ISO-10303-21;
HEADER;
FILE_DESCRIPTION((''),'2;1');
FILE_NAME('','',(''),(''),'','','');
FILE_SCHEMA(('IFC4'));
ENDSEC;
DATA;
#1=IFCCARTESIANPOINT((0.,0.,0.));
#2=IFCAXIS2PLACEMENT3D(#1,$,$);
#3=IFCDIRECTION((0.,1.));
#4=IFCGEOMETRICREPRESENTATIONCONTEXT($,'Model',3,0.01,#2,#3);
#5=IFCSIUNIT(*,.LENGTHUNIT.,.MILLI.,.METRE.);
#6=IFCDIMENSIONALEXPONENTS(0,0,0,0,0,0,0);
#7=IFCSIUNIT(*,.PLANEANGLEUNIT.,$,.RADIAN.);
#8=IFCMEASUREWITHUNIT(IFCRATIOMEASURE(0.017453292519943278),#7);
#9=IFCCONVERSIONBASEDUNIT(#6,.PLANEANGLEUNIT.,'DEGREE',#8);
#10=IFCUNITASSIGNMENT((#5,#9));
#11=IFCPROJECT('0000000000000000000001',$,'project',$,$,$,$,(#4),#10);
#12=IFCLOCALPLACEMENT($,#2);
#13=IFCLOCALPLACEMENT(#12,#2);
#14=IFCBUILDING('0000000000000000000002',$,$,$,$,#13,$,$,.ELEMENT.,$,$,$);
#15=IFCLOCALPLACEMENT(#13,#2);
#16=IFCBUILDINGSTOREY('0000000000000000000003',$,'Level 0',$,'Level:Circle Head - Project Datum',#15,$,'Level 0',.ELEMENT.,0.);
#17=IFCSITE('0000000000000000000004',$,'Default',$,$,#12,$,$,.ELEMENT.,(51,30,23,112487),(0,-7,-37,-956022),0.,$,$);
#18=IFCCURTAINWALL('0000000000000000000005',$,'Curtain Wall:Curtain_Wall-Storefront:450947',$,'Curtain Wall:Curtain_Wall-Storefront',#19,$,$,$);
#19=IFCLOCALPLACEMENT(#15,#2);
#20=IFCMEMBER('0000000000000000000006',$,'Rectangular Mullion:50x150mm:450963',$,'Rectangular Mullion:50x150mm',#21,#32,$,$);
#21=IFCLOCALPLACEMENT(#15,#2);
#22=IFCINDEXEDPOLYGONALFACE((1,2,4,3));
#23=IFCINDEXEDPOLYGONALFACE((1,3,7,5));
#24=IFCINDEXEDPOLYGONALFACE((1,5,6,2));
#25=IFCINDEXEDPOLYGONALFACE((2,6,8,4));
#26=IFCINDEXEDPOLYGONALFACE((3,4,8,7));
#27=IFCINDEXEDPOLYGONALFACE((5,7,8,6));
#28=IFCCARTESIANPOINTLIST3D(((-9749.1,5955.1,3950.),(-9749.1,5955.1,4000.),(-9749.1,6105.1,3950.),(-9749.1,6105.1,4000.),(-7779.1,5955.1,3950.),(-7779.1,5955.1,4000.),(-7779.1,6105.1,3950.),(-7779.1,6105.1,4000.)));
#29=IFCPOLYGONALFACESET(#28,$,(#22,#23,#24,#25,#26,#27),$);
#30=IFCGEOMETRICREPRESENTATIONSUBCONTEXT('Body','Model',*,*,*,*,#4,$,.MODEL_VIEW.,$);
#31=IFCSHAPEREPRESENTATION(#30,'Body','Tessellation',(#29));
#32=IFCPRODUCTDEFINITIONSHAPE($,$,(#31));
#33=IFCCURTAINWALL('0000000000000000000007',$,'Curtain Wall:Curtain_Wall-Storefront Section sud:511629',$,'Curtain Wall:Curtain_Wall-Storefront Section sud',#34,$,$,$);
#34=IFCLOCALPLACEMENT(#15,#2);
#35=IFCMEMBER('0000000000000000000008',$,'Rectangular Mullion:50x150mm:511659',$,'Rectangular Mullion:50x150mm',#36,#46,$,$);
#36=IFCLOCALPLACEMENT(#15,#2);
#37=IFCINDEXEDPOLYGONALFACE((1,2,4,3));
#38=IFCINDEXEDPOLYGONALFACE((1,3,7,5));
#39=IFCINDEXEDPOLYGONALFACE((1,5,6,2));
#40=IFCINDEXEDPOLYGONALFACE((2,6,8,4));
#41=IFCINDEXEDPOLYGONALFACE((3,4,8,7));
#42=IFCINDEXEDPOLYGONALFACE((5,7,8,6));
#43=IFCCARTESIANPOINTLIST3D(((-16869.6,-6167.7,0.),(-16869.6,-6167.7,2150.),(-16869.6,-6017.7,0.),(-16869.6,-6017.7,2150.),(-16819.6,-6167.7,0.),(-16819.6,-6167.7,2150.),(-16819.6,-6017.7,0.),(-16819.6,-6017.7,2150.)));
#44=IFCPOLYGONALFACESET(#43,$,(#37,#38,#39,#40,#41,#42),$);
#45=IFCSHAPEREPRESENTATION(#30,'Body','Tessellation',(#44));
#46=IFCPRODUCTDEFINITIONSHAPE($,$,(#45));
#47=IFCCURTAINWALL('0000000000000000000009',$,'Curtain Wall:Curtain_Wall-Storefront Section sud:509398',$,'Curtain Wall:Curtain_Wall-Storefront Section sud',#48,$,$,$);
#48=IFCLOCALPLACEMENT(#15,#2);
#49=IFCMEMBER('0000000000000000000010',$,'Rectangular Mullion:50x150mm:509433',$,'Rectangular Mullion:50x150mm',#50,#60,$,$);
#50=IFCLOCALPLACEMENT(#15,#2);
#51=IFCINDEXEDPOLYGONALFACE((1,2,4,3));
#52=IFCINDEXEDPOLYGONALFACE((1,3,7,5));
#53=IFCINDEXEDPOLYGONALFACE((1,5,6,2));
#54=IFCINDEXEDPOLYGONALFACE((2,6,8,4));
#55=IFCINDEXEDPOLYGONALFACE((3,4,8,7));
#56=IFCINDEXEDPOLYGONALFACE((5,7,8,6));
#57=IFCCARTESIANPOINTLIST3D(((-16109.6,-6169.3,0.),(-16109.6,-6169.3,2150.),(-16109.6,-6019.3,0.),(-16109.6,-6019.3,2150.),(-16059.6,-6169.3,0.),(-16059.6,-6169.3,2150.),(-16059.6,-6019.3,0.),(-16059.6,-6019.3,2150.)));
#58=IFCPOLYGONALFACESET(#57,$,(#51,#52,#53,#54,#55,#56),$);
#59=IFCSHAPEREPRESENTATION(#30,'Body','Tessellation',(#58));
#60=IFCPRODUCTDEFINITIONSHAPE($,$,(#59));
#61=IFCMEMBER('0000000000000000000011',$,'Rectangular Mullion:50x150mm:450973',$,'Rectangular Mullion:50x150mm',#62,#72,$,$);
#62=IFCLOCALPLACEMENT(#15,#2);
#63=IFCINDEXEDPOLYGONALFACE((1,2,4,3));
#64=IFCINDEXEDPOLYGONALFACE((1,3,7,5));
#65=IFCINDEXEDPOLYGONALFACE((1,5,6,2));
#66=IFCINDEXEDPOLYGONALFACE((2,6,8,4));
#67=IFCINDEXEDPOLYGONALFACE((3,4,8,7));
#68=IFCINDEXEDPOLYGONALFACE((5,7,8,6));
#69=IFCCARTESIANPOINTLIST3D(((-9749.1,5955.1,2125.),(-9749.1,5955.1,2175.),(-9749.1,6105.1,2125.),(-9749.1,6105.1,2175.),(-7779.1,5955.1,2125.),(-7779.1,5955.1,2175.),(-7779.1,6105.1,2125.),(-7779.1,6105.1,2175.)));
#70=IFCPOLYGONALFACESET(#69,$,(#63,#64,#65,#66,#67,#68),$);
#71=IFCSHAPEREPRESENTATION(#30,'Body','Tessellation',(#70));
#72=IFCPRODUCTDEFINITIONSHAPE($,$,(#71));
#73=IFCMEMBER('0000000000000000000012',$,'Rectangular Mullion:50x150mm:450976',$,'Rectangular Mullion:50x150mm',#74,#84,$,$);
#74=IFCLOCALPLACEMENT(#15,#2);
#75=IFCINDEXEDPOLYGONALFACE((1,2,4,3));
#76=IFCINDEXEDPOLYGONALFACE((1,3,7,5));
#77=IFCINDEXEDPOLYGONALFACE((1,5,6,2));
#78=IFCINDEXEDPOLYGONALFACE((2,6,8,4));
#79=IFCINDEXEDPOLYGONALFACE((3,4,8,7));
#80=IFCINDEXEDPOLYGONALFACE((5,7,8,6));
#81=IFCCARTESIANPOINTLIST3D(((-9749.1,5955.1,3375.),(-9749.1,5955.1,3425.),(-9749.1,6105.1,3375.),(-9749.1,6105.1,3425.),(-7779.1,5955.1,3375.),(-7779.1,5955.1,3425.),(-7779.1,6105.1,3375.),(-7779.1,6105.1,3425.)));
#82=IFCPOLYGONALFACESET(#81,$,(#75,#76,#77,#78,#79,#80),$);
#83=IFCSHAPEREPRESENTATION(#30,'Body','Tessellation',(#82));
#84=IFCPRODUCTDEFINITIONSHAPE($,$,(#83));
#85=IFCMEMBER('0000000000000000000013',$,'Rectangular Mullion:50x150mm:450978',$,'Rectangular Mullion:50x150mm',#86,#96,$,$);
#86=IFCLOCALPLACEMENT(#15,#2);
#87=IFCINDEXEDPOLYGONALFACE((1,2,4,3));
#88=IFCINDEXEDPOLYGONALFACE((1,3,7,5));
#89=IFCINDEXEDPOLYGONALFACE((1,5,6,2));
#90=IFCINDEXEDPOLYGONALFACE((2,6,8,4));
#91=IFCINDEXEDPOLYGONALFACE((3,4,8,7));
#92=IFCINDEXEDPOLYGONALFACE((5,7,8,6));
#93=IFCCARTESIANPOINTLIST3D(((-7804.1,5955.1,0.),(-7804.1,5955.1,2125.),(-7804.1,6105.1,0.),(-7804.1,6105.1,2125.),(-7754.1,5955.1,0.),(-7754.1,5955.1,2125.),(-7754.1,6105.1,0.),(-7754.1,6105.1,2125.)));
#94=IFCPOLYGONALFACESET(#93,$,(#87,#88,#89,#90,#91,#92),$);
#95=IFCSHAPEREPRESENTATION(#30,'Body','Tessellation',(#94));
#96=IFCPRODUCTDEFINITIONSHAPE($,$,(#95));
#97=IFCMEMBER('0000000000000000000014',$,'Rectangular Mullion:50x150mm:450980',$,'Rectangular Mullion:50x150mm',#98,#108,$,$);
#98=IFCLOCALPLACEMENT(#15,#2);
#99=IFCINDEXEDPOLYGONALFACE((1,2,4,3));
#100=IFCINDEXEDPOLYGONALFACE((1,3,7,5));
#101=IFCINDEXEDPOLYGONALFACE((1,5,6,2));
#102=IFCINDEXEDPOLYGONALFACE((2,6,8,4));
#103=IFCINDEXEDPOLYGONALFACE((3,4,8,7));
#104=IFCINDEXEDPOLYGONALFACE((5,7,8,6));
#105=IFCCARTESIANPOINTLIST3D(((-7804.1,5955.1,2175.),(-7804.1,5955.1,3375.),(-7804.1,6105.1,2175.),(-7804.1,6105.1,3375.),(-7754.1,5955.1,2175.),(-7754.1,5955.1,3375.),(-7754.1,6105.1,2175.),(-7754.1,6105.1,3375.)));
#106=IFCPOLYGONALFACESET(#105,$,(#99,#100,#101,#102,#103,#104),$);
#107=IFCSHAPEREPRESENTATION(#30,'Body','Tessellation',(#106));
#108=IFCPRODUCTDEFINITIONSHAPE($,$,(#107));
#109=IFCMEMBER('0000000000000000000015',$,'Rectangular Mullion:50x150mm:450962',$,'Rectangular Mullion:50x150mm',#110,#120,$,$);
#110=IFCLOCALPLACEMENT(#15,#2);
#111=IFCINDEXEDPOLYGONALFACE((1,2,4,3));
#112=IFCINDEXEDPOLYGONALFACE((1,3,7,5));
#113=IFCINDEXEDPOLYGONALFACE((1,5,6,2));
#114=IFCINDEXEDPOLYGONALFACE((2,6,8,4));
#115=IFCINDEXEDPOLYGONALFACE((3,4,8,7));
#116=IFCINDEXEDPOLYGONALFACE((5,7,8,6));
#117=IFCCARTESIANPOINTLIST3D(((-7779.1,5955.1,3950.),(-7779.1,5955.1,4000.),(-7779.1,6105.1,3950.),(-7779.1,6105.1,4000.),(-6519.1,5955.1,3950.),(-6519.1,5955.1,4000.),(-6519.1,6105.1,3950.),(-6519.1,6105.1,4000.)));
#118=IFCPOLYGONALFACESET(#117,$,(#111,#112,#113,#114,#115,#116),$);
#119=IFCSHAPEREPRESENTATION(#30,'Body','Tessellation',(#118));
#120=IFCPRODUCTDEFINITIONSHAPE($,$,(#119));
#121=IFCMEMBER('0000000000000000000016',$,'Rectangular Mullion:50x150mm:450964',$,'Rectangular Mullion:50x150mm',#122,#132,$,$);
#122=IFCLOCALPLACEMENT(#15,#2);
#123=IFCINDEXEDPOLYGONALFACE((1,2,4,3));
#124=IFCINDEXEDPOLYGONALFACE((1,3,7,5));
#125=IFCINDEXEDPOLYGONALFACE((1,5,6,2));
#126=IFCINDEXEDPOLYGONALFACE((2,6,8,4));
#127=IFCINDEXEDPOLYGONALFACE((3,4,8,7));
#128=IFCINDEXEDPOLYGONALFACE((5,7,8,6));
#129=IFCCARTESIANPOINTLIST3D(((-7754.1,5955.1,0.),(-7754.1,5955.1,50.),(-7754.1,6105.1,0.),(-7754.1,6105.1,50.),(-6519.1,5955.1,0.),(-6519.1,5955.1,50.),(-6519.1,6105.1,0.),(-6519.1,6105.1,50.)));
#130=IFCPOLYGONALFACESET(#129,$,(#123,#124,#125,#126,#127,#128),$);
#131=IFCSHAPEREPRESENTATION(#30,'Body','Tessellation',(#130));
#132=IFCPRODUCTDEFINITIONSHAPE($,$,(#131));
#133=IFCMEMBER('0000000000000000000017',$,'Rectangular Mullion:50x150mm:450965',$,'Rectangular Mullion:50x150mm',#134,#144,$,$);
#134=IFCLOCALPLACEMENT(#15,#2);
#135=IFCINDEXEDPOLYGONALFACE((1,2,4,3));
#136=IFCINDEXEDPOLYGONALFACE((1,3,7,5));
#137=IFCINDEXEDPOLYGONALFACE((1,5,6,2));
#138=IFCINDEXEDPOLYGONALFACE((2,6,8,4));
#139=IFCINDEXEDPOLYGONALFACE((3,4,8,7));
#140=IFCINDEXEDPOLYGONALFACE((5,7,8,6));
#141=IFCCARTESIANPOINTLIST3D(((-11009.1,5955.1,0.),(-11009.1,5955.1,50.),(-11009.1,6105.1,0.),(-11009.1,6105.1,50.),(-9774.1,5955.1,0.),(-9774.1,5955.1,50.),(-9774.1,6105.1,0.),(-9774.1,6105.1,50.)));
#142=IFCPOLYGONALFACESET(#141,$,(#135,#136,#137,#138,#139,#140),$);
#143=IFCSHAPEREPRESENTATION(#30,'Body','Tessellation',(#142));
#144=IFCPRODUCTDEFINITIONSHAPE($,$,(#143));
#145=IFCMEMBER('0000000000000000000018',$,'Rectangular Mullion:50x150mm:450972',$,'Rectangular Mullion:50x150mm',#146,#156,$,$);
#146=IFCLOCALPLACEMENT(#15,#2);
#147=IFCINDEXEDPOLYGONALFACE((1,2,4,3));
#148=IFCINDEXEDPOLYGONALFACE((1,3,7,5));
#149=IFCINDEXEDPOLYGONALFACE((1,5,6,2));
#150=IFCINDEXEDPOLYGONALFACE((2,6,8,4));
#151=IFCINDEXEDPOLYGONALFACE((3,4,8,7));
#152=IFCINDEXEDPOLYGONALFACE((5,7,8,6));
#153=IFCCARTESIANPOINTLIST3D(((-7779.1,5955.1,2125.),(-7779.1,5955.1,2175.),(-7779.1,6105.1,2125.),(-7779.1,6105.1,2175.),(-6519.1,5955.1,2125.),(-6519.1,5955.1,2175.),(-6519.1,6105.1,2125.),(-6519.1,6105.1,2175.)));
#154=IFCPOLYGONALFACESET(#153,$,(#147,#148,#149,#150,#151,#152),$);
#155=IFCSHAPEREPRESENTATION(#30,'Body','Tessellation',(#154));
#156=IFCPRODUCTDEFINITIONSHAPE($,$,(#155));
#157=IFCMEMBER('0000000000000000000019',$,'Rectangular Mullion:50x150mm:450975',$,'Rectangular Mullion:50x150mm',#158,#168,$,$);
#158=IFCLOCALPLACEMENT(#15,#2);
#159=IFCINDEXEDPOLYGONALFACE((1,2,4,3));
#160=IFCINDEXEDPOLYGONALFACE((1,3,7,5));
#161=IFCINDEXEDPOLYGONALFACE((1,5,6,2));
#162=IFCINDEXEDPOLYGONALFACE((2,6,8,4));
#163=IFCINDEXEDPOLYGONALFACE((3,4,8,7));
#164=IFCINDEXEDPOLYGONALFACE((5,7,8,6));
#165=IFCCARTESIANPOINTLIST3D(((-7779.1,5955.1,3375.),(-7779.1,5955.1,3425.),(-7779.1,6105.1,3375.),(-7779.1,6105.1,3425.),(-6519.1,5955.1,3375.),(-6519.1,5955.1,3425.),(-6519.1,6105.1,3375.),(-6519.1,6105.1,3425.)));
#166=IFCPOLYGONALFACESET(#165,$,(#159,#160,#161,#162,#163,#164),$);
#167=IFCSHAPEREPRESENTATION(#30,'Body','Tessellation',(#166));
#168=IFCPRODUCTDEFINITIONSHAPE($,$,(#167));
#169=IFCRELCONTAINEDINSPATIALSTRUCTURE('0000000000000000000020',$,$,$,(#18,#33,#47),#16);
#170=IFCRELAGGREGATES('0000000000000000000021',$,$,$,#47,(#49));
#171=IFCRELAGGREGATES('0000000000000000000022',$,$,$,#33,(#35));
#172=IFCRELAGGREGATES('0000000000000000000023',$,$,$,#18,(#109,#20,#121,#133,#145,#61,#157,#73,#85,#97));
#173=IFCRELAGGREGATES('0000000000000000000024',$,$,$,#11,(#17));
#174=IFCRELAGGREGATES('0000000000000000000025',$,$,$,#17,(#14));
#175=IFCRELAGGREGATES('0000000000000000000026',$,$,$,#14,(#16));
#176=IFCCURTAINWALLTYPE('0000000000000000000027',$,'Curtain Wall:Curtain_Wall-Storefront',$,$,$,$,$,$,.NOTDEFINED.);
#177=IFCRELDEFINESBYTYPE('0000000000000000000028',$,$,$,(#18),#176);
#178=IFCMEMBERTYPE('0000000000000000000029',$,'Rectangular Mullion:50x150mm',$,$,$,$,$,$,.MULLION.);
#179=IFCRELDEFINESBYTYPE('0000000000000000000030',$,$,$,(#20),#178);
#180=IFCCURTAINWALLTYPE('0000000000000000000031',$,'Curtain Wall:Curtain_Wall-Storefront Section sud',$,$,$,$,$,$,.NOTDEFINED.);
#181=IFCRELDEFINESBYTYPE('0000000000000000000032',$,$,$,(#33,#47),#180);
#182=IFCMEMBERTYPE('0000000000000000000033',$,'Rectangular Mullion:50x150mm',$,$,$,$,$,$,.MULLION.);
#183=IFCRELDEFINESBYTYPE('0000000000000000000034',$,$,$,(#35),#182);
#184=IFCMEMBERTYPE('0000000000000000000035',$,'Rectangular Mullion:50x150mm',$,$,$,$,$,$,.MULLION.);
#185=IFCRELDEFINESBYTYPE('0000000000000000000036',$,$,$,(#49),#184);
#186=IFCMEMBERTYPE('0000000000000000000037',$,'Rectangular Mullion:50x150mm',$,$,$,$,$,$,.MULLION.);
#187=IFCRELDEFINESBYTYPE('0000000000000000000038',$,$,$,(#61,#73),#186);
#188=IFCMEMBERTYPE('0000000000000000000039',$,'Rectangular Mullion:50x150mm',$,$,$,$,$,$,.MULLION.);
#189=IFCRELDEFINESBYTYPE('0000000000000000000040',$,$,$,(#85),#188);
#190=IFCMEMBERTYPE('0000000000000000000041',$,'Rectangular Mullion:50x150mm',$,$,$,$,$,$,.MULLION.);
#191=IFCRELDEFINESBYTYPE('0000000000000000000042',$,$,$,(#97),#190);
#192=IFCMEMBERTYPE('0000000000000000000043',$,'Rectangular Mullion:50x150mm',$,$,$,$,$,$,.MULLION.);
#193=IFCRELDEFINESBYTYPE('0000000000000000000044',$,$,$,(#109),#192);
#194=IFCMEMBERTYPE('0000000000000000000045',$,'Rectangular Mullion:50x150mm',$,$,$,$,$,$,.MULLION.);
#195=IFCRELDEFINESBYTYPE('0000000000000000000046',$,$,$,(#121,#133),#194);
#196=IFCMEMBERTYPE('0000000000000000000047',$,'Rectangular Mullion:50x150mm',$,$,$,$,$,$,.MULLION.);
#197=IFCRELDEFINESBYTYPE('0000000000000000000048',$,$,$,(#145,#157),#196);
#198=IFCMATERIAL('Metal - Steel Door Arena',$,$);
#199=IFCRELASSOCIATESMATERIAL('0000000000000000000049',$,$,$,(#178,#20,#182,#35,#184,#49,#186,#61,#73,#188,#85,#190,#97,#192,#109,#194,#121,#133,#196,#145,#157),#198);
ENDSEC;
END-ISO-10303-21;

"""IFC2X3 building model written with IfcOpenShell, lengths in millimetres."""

from ifc_helpers import new_model, entity, si_unit, converted_unit, direction, frame, origin, origin_2d_with_axis, place, context, subcontext, project, spatial, rectangle, extrude, source, transform, mapped, material, type_object, type_shapes, element, aggregate, save


model = new_model("IFC2X3")

# Units and contexts
model_context = context("Model", 3, precision=0.01, world=origin(), true_north=direction((0.0, 1.0)))
body_context = subcontext(model_context, "Body", "Model", "MODEL_VIEW")
ifc_project = project(units=[si_unit("LENGTHUNIT", "METRE", prefix="MILLI"), converted_unit("PLANEANGLEUNIT", "DEGREE", entity("IfcRatioMeasure", 0.017453292519943278), si_unit("PLANEANGLEUNIT", "RADIAN"), dimensions=[0, 0, 0, 0, 0, 0, 0])], contexts=[model_context])

# Site, building, storey
site_placement = place(None, origin())
site = spatial("IfcSite", under=ifc_project, at=site_placement, Name="Default", CompositionType="ELEMENT", RefLatitude=(51, 30, 23, 112487), RefLongitude=(0, -7, -37, -956022), RefElevation=0.0)
building_placement = place(site_placement, origin())
building = spatial("IfcBuilding", under=site, at=building_placement, CompositionType="ELEMENT")
storey_placement = place(building_placement, origin())
storey = spatial("IfcBuildingStorey", under=building, at=storey_placement, Name="Level 0", ObjectType="Level:Circle Head - Project Datum", LongName="Level 0", CompositionType="ELEMENT", Elevation=0.0)

# Curtain walls, members
curtain_wall_type_1 = type_object("IfcCurtainWallType", Name="Curtain Wall:Curtain_Wall-Storefront", PredefinedType="NOTDEFINED")
curtain_wall_1_placement = place(storey_placement, origin())
curtain_wall_1 = element("IfcCurtainWall", 1, at=curtain_wall_1_placement, inside=storey, type_object=curtain_wall_type_1, Name="Curtain Wall:Curtain_Wall-Storefront:450947", ObjectType="Curtain Wall:Curtain_Wall-Storefront")
ifc_material_1 = material(Name="Metal - Steel Door Arena")
member_type_1 = type_object("IfcMemberType", Name="Rectangular Mullion:50x150mm", PredefinedType="MULLION", material=ifc_material_1)
shared_shape_1 = source(origin(), body_context, "Body", "SweptSolid", [
    extrude(rectangle(XDim=150.0, YDim=50.0, at=origin_2d_with_axis()), frame((-25.0, 0.0, -1970.0), z_axis=(0.0, 0.0, 1.0), x_axis=(0.0, -1.0, 0.0)), (0.0, 0.0, 1.0), 1970.0),
])
type_shapes(member_type_1, [shared_shape_1])
member_1_placement = place(curtain_wall_1_placement, frame((-9749.1, 6030.1, 4000.0), z_axis=(-1.0, 0.0, 0.0), x_axis=(0.0, 0.0, 1.0)))
member_1 = element("IfcMember", 2, at=member_1_placement, type_object=member_type_1, material=ifc_material_1, Name="Rectangular Mullion:50x150mm:450963", ObjectType="Rectangular Mullion:50x150mm", context=body_context, shape_type="MappedRepresentation", body=[
    mapped(shared_shape_1, transform((0.0, 0.0, 0.0), scale=1.0)),
])
curtain_wall_type_2 = type_object("IfcCurtainWallType", Name="Curtain Wall:Curtain_Wall-Storefront Section sud", PredefinedType="NOTDEFINED")
curtain_wall_2_placement = place(storey_placement, origin())
curtain_wall_2 = element("IfcCurtainWall", 3, at=curtain_wall_2_placement, inside=storey, type_object=curtain_wall_type_2, Name="Curtain Wall:Curtain_Wall-Storefront Section sud:511629", ObjectType="Curtain Wall:Curtain_Wall-Storefront Section sud")
member_type_2 = type_object("IfcMemberType", Name="Rectangular Mullion:50x150mm", PredefinedType="MULLION", material=ifc_material_1)
shared_shape_2 = source(origin(), body_context, "Body", "SweptSolid", [
    extrude(rectangle(XDim=150.0, YDim=50.0, at=origin_2d_with_axis()), frame((-25.0, 0.0, -2150.0), z_axis=(0.0, 0.0, 1.0), x_axis=(0.0, -1.0, 0.0)), (0.0, 0.0, 1.0), 2150.0),
])
type_shapes(member_type_2, [shared_shape_2])
member_2_placement = place(curtain_wall_2_placement, frame((-16819.6, -6092.7, 0.0), z_axis=(0.0, 0.0, -1.0), x_axis=(1.0, 0.0, 0.0)))
member_2 = element("IfcMember", 4, at=member_2_placement, type_object=member_type_2, material=ifc_material_1, Name="Rectangular Mullion:50x150mm:511659", ObjectType="Rectangular Mullion:50x150mm", context=body_context, shape_type="MappedRepresentation", body=[
    mapped(shared_shape_2, transform((0.0, 0.0, 0.0), scale=1.0)),
])
curtain_wall_3_placement = place(storey_placement, origin())
curtain_wall_3 = element("IfcCurtainWall", 5, at=curtain_wall_3_placement, inside=storey, type_object=curtain_wall_type_2, Name="Curtain Wall:Curtain_Wall-Storefront Section sud:509398", ObjectType="Curtain Wall:Curtain_Wall-Storefront Section sud")
member_type_3 = type_object("IfcMemberType", Name="Rectangular Mullion:50x150mm", PredefinedType="MULLION", material=ifc_material_1)
shared_shape_3 = source(origin(), body_context, "Body", "SweptSolid", [
    extrude(rectangle(XDim=150.0, YDim=50.0, at=origin_2d_with_axis()), frame((-25.0, 0.0, -2150.0), z_axis=(0.0, 0.0, 1.0), x_axis=(0.0, -1.0, 0.0)), (0.0, 0.0, 1.0), 2150.0),
])
type_shapes(member_type_3, [shared_shape_3])
member_3_placement = place(curtain_wall_3_placement, frame((-16109.6, -6094.3, 2150.0), z_axis=(0.0, 0.0, 1.0), x_axis=(-1.0, 0.0, 0.0)))
member_3 = element("IfcMember", 6, at=member_3_placement, type_object=member_type_3, material=ifc_material_1, Name="Rectangular Mullion:50x150mm:509433", ObjectType="Rectangular Mullion:50x150mm", context=body_context, shape_type="MappedRepresentation", body=[
    mapped(shared_shape_3, transform((0.0, 0.0, 0.0), scale=1.0)),
])

# Members
member_type_4 = type_object("IfcMemberType", Name="Rectangular Mullion:50x150mm", PredefinedType="MULLION", material=ifc_material_1)
shared_shape_4 = source(origin(), body_context, "Body", "SweptSolid", [
    extrude(rectangle(XDim=150.0, YDim=50.0, at=origin_2d_with_axis()), frame((0.0, 0.0, -1970.0), z_axis=(0.0, 0.0, 1.0), x_axis=(0.0, -1.0, 0.0)), (0.0, 0.0, 1.0), 1970.0),
])
type_shapes(member_type_4, [shared_shape_4])
member_4_placement = place(curtain_wall_1_placement, frame((-9749.1, 6030.1, 2150.0), z_axis=(-1.0, 0.0, 0.0), x_axis=(0.0, 0.0, 1.0)))
member_4 = element("IfcMember", 7, at=member_4_placement, type_object=member_type_4, material=ifc_material_1, Name="Rectangular Mullion:50x150mm:450973", ObjectType="Rectangular Mullion:50x150mm", context=body_context, shape_type="MappedRepresentation", body=[
    mapped(shared_shape_4, transform((0.0, 0.0, 0.0), scale=1.0)),
])
member_5_placement = place(curtain_wall_1_placement, frame((-9749.1, 6030.1, 3400.0), z_axis=(-1.0, 0.0, 0.0), x_axis=(0.0, 0.0, 1.0)))
member_5 = element("IfcMember", 8, at=member_5_placement, type_object=member_type_4, material=ifc_material_1, Name="Rectangular Mullion:50x150mm:450976", ObjectType="Rectangular Mullion:50x150mm", context=body_context, shape_type="MappedRepresentation", body=[
    mapped(shared_shape_4, transform((0.0, 0.0, 0.0), scale=1.0)),
])
member_type_5 = type_object("IfcMemberType", Name="Rectangular Mullion:50x150mm", PredefinedType="MULLION", material=ifc_material_1)
shared_shape_5 = source(origin(), body_context, "Body", "SweptSolid", [
    extrude(rectangle(XDim=150.0, YDim=50.0, at=origin_2d_with_axis()), frame((0.0, 0.0, -2125.0), z_axis=(0.0, 0.0, 1.0), x_axis=(0.0, -1.0, 0.0)), (0.0, 0.0, 1.0), 2125.0),
])
type_shapes(member_type_5, [shared_shape_5])
member_6_placement = place(curtain_wall_1_placement, frame((-7779.1, 6030.1, 0.0), z_axis=(0.0, 0.0, -1.0), x_axis=(-1.0, 0.0, 0.0)))
member_6 = element("IfcMember", 9, at=member_6_placement, type_object=member_type_5, material=ifc_material_1, Name="Rectangular Mullion:50x150mm:450978", ObjectType="Rectangular Mullion:50x150mm", context=body_context, shape_type="MappedRepresentation", body=[
    mapped(shared_shape_5, transform((0.0, 0.0, 0.0), scale=1.0)),
])
member_type_6 = type_object("IfcMemberType", Name="Rectangular Mullion:50x150mm", PredefinedType="MULLION", material=ifc_material_1)
shared_shape_6 = source(origin(), body_context, "Body", "SweptSolid", [
    extrude(rectangle(XDim=150.0, YDim=50.0, at=origin_2d_with_axis()), frame((0.0, 0.0, -1200.0), z_axis=(0.0, 0.0, 1.0), x_axis=(0.0, -1.0, 0.0)), (0.0, 0.0, 1.0), 1200.0),
])
type_shapes(member_type_6, [shared_shape_6])
member_7_placement = place(curtain_wall_1_placement, frame((-7779.1, 6030.1, 2175.0), z_axis=(0.0, 0.0, -1.0), x_axis=(-1.0, 0.0, 0.0)))
member_7 = element("IfcMember", 10, at=member_7_placement, type_object=member_type_6, material=ifc_material_1, Name="Rectangular Mullion:50x150mm:450980", ObjectType="Rectangular Mullion:50x150mm", context=body_context, shape_type="MappedRepresentation", body=[
    mapped(shared_shape_6, transform((0.0, 0.0, 0.0), scale=1.0)),
])
member_type_7 = type_object("IfcMemberType", Name="Rectangular Mullion:50x150mm", PredefinedType="MULLION", material=ifc_material_1)
shared_shape_7 = source(origin(), body_context, "Body", "SweptSolid", [
    extrude(rectangle(XDim=150.0, YDim=50.0, at=origin_2d_with_axis()), frame((-25.0, 0.0, -1260.0), z_axis=(0.0, 0.0, 1.0), x_axis=(0.0, -1.0, 0.0)), (0.0, 0.0, 1.0), 1260.0),
])
type_shapes(member_type_7, [shared_shape_7])
member_8_placement = place(curtain_wall_1_placement, frame((-7779.1, 6030.1, 4000.0), z_axis=(-1.0, 0.0, 0.0), x_axis=(0.0, 0.0, 1.0)))
member_8 = element("IfcMember", 11, at=member_8_placement, type_object=member_type_7, material=ifc_material_1, Name="Rectangular Mullion:50x150mm:450962", ObjectType="Rectangular Mullion:50x150mm", context=body_context, shape_type="MappedRepresentation", body=[
    mapped(shared_shape_7, transform((0.0, 0.0, 0.0), scale=1.0)),
])
member_type_8 = type_object("IfcMemberType", Name="Rectangular Mullion:50x150mm", PredefinedType="MULLION", material=ifc_material_1)
shared_shape_8 = source(origin(), body_context, "Body", "SweptSolid", [
    extrude(rectangle(XDim=150.0, YDim=50.0, at=origin_2d_with_axis()), frame((-25.0, 0.0, -1235.0), z_axis=(0.0, 0.0, 1.0), x_axis=(0.0, -1.0, 0.0)), (0.0, 0.0, 1.0), 1235.0),
])
type_shapes(member_type_8, [shared_shape_8])
member_9_placement = place(curtain_wall_1_placement, frame((-6519.1, 6030.1, 0.0), z_axis=(1.0, 0.0, 0.0), x_axis=(0.0, 0.0, -1.0)))
member_9 = element("IfcMember", 12, at=member_9_placement, type_object=member_type_8, material=ifc_material_1, Name="Rectangular Mullion:50x150mm:450964", ObjectType="Rectangular Mullion:50x150mm", context=body_context, shape_type="MappedRepresentation", body=[
    mapped(shared_shape_8, transform((0.0, 0.0, 0.0), scale=1.0)),
])
member_10_placement = place(curtain_wall_1_placement, frame((-9774.1, 6030.1, 0.0), z_axis=(1.0, 0.0, 0.0), x_axis=(0.0, 0.0, -1.0)))
member_10 = element("IfcMember", 13, at=member_10_placement, type_object=member_type_8, material=ifc_material_1, Name="Rectangular Mullion:50x150mm:450965", ObjectType="Rectangular Mullion:50x150mm", context=body_context, shape_type="MappedRepresentation", body=[
    mapped(shared_shape_8, transform((0.0, 0.0, 0.0), scale=1.0)),
])
member_type_9 = type_object("IfcMemberType", Name="Rectangular Mullion:50x150mm", PredefinedType="MULLION", material=ifc_material_1)
shared_shape_9 = source(origin(), body_context, "Body", "SweptSolid", [
    extrude(rectangle(XDim=150.0, YDim=50.0, at=origin_2d_with_axis()), frame((0.0, 0.0, -1260.0), z_axis=(0.0, 0.0, 1.0), x_axis=(0.0, -1.0, 0.0)), (0.0, 0.0, 1.0), 1260.0),
])
type_shapes(member_type_9, [shared_shape_9])
member_11_placement = place(curtain_wall_1_placement, frame((-7779.1, 6030.1, 2150.0), z_axis=(-1.0, 0.0, 0.0), x_axis=(0.0, 0.0, 1.0)))
member_11 = element("IfcMember", 14, at=member_11_placement, type_object=member_type_9, material=ifc_material_1, Name="Rectangular Mullion:50x150mm:450972", ObjectType="Rectangular Mullion:50x150mm", context=body_context, shape_type="MappedRepresentation", body=[
    mapped(shared_shape_9, transform((0.0, 0.0, 0.0), scale=1.0)),
])
member_12_placement = place(curtain_wall_1_placement, frame((-7779.1, 6030.1, 3400.0), z_axis=(-1.0, 0.0, 0.0), x_axis=(0.0, 0.0, 1.0)))
member_12 = element("IfcMember", 15, at=member_12_placement, type_object=member_type_9, material=ifc_material_1, Name="Rectangular Mullion:50x150mm:450975", ObjectType="Rectangular Mullion:50x150mm", context=body_context, shape_type="MappedRepresentation", body=[
    mapped(shared_shape_9, transform((0.0, 0.0, 0.0), scale=1.0)),
])
aggregate(curtain_wall_3, [member_3])
aggregate(curtain_wall_2, [member_2])

aggregate(curtain_wall_1, [member_8, member_1, member_9, member_10, member_11, member_4, member_12, member_5, member_6, member_7])

save(model, "model.ifc")
